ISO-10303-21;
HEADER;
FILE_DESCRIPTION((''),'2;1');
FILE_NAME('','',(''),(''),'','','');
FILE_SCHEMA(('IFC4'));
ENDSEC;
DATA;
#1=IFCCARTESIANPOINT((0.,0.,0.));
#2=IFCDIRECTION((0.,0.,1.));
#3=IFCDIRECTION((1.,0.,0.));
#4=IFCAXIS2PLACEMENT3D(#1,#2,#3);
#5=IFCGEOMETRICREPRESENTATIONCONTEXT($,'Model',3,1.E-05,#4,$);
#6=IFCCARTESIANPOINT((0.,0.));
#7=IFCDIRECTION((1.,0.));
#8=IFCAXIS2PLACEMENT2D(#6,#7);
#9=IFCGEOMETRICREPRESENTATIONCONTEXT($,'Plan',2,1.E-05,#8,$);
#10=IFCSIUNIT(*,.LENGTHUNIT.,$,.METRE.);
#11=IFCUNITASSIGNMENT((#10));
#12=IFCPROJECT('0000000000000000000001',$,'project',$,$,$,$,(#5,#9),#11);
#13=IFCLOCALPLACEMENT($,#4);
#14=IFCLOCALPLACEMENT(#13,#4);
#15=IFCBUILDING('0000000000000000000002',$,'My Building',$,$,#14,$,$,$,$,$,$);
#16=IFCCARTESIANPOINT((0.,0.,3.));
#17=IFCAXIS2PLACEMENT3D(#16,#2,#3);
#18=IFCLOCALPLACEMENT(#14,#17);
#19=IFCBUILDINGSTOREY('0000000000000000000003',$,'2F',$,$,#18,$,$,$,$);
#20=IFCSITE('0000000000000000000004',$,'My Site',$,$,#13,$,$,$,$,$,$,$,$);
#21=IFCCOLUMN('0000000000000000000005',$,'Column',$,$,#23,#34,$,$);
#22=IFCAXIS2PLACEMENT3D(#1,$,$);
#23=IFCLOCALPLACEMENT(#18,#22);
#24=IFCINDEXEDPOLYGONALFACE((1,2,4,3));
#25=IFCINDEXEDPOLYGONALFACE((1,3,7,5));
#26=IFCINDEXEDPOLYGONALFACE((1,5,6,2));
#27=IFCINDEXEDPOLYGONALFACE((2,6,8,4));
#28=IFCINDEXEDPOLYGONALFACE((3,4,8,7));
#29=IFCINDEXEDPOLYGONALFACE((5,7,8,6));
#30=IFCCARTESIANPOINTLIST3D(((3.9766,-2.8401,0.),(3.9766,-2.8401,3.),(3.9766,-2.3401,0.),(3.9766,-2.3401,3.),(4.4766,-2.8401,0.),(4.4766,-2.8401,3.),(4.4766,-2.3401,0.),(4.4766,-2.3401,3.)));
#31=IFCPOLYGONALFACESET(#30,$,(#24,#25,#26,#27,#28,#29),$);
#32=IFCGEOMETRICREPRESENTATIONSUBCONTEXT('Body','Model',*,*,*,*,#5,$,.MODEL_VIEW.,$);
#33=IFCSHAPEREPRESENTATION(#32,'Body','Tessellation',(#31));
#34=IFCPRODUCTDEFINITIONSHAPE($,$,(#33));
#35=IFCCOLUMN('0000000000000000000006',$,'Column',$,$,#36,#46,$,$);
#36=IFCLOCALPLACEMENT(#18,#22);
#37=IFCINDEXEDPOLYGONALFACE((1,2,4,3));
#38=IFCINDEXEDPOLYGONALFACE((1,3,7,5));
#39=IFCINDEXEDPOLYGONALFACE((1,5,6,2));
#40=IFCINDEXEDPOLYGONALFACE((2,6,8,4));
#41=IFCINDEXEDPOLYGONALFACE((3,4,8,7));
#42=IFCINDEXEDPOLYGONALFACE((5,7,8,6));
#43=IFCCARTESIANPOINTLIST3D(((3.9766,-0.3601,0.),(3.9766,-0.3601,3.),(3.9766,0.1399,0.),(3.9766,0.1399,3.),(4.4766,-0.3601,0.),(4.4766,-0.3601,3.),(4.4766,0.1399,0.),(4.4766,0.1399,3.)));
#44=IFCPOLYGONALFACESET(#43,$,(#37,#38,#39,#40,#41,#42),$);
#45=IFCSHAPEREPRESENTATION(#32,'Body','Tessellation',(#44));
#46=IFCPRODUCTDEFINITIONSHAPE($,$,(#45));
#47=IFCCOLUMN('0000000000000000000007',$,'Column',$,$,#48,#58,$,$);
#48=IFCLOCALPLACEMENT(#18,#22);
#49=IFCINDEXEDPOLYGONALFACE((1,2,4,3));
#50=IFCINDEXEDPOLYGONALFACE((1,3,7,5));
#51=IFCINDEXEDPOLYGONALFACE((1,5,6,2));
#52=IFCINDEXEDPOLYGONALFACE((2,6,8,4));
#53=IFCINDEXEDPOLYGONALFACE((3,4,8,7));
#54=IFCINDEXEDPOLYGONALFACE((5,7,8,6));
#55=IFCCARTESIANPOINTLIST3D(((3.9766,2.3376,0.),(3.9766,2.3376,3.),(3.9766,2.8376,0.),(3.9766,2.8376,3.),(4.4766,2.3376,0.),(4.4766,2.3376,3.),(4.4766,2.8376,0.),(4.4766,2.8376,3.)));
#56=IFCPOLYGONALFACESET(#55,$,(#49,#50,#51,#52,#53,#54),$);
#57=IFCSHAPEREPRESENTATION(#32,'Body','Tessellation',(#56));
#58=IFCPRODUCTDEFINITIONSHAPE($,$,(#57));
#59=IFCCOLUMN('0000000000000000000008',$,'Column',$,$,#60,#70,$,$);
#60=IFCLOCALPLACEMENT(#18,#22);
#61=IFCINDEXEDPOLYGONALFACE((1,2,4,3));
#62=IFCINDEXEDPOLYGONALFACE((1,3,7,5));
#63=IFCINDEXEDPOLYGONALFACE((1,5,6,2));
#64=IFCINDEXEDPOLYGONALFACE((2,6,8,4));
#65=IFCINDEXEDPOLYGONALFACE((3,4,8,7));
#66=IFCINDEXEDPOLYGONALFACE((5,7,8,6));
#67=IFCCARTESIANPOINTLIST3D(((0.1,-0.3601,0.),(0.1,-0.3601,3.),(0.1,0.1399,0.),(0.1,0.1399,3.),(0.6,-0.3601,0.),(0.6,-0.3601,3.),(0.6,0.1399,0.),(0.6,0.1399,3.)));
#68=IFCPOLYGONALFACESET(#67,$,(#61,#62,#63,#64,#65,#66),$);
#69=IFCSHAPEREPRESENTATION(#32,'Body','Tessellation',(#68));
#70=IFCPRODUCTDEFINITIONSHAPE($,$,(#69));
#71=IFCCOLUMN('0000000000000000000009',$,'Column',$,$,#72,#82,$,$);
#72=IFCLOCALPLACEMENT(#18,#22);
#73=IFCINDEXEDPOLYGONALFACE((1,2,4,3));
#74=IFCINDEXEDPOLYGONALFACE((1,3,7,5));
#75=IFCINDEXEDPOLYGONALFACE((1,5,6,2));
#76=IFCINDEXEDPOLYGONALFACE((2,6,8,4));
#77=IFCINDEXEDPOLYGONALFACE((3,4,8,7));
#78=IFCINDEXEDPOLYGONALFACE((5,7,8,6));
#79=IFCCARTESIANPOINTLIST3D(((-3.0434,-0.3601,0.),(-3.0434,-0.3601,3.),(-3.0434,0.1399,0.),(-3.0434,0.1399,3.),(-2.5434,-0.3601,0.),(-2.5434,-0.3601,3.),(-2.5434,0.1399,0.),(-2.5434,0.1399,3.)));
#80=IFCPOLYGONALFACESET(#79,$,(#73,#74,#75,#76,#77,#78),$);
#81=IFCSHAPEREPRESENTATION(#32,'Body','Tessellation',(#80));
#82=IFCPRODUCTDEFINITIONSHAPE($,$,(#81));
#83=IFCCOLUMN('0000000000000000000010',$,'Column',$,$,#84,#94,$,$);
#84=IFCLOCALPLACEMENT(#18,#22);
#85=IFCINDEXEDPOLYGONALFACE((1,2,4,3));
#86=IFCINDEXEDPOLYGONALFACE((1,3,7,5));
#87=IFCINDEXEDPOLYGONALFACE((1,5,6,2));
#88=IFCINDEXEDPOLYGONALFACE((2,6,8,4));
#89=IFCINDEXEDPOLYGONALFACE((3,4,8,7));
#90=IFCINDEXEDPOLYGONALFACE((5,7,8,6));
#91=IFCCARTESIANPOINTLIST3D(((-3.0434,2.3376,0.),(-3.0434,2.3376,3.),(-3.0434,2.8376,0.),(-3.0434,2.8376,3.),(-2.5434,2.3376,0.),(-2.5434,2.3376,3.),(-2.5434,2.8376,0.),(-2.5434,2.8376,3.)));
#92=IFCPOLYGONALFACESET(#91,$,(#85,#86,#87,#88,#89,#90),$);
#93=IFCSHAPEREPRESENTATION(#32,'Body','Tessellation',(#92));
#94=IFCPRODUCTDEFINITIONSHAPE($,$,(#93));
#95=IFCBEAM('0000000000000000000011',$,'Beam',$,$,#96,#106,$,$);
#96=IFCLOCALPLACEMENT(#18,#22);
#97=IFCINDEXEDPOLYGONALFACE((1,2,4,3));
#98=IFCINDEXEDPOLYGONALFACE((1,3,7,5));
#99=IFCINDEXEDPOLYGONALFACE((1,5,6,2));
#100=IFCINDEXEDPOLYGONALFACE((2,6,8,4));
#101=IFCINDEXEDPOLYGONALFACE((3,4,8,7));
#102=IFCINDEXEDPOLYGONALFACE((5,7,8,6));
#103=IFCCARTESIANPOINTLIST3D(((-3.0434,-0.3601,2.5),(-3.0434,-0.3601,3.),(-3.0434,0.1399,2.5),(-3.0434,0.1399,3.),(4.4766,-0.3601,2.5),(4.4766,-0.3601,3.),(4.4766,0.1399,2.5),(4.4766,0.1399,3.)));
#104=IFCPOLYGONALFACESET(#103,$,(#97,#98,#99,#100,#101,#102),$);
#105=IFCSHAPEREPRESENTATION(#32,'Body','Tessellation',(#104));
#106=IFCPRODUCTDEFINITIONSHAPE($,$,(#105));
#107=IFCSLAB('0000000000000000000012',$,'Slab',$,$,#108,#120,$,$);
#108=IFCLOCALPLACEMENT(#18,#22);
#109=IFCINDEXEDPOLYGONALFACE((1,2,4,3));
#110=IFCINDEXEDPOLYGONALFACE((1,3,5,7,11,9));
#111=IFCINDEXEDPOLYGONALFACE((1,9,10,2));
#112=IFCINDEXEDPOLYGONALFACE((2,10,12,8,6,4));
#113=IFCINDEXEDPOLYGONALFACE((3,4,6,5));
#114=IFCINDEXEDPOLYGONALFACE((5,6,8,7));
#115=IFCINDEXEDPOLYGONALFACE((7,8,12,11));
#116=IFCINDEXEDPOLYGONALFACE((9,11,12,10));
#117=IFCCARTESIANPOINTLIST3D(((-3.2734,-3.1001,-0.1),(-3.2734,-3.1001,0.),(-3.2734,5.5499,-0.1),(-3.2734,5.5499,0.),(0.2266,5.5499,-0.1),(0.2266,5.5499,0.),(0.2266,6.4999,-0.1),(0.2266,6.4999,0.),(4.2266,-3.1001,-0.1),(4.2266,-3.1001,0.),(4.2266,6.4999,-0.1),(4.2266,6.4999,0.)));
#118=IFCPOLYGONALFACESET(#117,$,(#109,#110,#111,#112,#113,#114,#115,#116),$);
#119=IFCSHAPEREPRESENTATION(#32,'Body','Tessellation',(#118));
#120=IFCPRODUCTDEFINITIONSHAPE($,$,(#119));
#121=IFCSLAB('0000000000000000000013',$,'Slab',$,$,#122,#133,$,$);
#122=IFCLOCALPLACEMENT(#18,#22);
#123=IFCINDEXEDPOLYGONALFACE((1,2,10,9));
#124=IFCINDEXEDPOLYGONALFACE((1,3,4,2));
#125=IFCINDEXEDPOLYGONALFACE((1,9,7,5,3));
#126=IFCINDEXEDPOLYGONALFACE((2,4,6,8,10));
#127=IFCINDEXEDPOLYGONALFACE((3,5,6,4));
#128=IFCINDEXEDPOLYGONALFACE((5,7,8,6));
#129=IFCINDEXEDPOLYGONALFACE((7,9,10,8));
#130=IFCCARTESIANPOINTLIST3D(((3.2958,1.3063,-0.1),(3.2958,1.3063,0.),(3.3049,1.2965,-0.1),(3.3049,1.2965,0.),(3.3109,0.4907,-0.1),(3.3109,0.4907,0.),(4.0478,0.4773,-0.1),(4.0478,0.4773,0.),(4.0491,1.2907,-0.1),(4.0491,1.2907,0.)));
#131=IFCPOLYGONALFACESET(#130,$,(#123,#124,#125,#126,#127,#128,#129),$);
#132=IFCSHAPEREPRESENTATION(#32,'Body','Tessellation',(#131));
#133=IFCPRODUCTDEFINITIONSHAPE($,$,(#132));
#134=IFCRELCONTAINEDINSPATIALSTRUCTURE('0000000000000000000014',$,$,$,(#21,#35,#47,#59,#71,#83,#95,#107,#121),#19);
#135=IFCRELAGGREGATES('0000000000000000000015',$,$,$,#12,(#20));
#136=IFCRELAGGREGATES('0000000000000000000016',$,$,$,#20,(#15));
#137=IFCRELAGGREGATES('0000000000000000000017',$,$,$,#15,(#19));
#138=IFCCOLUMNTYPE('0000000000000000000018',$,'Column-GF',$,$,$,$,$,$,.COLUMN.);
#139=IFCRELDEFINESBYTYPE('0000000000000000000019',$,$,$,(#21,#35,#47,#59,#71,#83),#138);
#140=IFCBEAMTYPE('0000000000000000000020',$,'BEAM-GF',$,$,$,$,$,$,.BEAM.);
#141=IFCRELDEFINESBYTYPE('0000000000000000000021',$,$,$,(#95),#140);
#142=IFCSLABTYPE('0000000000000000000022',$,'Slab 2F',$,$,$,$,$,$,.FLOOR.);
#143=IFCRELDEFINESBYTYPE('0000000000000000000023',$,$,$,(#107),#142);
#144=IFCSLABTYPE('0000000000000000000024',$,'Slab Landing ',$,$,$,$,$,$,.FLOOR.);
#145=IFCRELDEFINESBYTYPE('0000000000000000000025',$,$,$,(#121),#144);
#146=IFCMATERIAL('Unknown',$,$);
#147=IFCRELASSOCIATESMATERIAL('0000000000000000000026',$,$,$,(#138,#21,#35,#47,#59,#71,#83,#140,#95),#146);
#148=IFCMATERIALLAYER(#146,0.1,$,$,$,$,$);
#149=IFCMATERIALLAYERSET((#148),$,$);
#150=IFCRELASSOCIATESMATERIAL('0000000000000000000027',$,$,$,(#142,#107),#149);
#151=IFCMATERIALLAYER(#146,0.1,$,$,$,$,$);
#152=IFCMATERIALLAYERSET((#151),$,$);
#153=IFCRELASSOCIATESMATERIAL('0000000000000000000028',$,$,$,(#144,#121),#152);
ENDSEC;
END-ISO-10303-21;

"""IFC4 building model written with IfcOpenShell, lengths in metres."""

from ifc_helpers import new_model, si_unit, frame, origin_with_axes, origin_2d_with_axis, place, context, subcontext, project, spatial, indexed_curve, rectangle, outline, extrude, material, layer, layer_set, layer_usage, material_profile, profile_set, profile_usage, type_object, element, save


model = new_model("IFC4")

# Units and contexts
model_context = context("Model", 3, precision=1e-05, world=origin_with_axes())
plan_context = context("Plan", 2, precision=1e-05, world=origin_2d_with_axis())
body_context_1 = subcontext(model_context, "Body", "Model", "MODEL_VIEW")
ifc_project = project(units=[si_unit("LENGTHUNIT", "METRE")], contexts=[model_context, plan_context])

# Site, building, storey
site_placement = place(None, origin_with_axes())
site = spatial("IfcSite", under=ifc_project, at=site_placement, Name="My Site")
building_placement = place(site_placement, origin_with_axes())
building = spatial("IfcBuilding", under=site, at=building_placement, Name="My Building")
storey_placement = place(building_placement, frame((0.0, 0.0, 3.0), z_axis=(0.0, 0.0, 1.0), x_axis=(1.0, 0.0, 0.0)))
storey = spatial("IfcBuildingStorey", under=building, at=storey_placement, Name="2F")

# Columns
ifc_material = material(Name="Unknown")
ifc_material_profile_1 = material_profile(ifc_material, rectangle(XDim=0.5, YDim=0.5))
ifc_profile_set_1 = profile_set([ifc_material_profile_1])
ifc_profile_usage_1 = profile_usage(ifc_profile_set_1, cardinal=5)
column_type = type_object("IfcColumnType", Name="Column-GF", PredefinedType="COLUMN", material=ifc_profile_set_1)
column_1_placement = place(storey_placement, frame((4.2266, -2.5901, 0.0), z_axis=(0.0, 0.0, 1.0), x_axis=(1.0, 0.0, 0.0)))
element("IfcColumn", 1, at=column_1_placement, inside=storey, type_object=column_type, material=ifc_profile_usage_1, Name="Column", context=body_context_1, shape_type="SweptSolid", body=[
    extrude(rectangle(XDim=0.5, YDim=0.5), origin_with_axes(), (0.0, 0.0, 1.0), 3.0),
])
ifc_profile_usage_2 = profile_usage(ifc_profile_set_1, cardinal=7)
column_2_placement = place(storey_placement, frame((4.4766, 0.1399, 0.0), z_axis=(0.0, 0.0, 1.0), x_axis=(1.0, 0.0, 0.0)))
element("IfcColumn", 2, at=column_2_placement, inside=storey, type_object=column_type, material=ifc_profile_usage_2, Name="Column", context=body_context_1, shape_type="SweptSolid", body=[
    extrude(rectangle(XDim=0.5, YDim=0.5), frame((-0.25, -0.25, 0.0), z_axis=(0.0, 0.0, 1.0), x_axis=(1.0, 0.0, 0.0)), (0.0, 0.0, 1.0), 3.0),
])
ifc_profile_usage_3 = profile_usage(ifc_profile_set_1, cardinal=7)
column_3_placement = place(storey_placement, frame((4.4766, 2.8376, 0.0), z_axis=(0.0, 0.0, 1.0), x_axis=(1.0, 0.0, 0.0)))
element("IfcColumn", 3, at=column_3_placement, inside=storey, type_object=column_type, material=ifc_profile_usage_3, Name="Column", context=body_context_1, shape_type="SweptSolid", body=[
    extrude(rectangle(XDim=0.5, YDim=0.5), frame((-0.25, -0.25, 0.0), z_axis=(0.0, 0.0, 1.0), x_axis=(1.0, 0.0, 0.0)), (0.0, 0.0, 1.0), 3.0),
])
ifc_profile_usage_4 = profile_usage(ifc_profile_set_1, cardinal=7)
column_4_placement = place(storey_placement, frame((0.6, 0.1399, 0.0), z_axis=(0.0, 0.0, 1.0), x_axis=(1.0, 0.0, 0.0)))
element("IfcColumn", 4, at=column_4_placement, inside=storey, type_object=column_type, material=ifc_profile_usage_4, Name="Column", context=body_context_1, shape_type="SweptSolid", body=[
    extrude(rectangle(XDim=0.5, YDim=0.5), frame((-0.25, -0.25, 0.0), z_axis=(0.0, 0.0, 1.0), x_axis=(1.0, 0.0, 0.0)), (0.0, 0.0, 1.0), 3.0),
])
ifc_profile_usage_5 = profile_usage(ifc_profile_set_1, cardinal=7)
column_5_placement = place(storey_placement, frame((-2.5434, 0.1399, 0.0), z_axis=(0.0, 0.0, 1.0), x_axis=(1.0, 0.0, 0.0)))
element("IfcColumn", 5, at=column_5_placement, inside=storey, type_object=column_type, material=ifc_profile_usage_5, Name="Column", context=body_context_1, shape_type="SweptSolid", body=[
    extrude(rectangle(XDim=0.5, YDim=0.5), frame((-0.25, -0.25, 0.0), z_axis=(0.0, 0.0, 1.0), x_axis=(1.0, 0.0, 0.0)), (0.0, 0.0, 1.0), 3.0),
])
ifc_profile_usage_6 = profile_usage(ifc_profile_set_1, cardinal=7)
column_6_placement = place(storey_placement, frame((-2.5434, 2.8376, 0.0), z_axis=(0.0, 0.0, 1.0), x_axis=(1.0, 0.0, 0.0)))
element("IfcColumn", 6, at=column_6_placement, inside=storey, type_object=column_type, material=ifc_profile_usage_6, Name="Column", context=body_context_1, shape_type="SweptSolid", body=[
    extrude(rectangle(XDim=0.5, YDim=0.5), frame((-0.25, -0.25, 0.0), z_axis=(0.0, 0.0, 1.0), x_axis=(1.0, 0.0, 0.0)), (0.0, 0.0, 1.0), 3.0),
])

# Beam
ifc_material_profile_2 = material_profile(ifc_material, rectangle(XDim=0.5, YDim=0.5))
ifc_profile_set_2 = profile_set([ifc_material_profile_2])
ifc_profile_usage_7 = profile_usage(ifc_profile_set_2, cardinal=7)
beam_type = type_object("IfcBeamType", Name="BEAM-GF", PredefinedType="BEAM", material=ifc_profile_set_2)
beam_placement = place(storey_placement, frame((-3.0434, 0.1399, 3.0), z_axis=(1.0, 0.0, 0.0), x_axis=(0.0, 1.0, 0.0)))
element("IfcBeam", 7, at=beam_placement, inside=storey, type_object=beam_type, material=ifc_profile_usage_7, Name="Beam", context=body_context_1, shape_type="SweptSolid", body=[
    extrude(rectangle(XDim=0.5, YDim=0.5), frame((-0.25, -0.25, 0.0), z_axis=(0.0, 0.0, 1.0), x_axis=(1.0, 0.0, 0.0)), (0.0, 0.0, 1.0), 7.52),
])

# Slabs
ifc_layer_1 = layer(ifc_material, 0.1)
ifc_layer_set_1 = layer_set([ifc_layer_1])
ifc_layer_usage_1 = layer_usage(ifc_layer_set_1, "AXIS3", "POSITIVE", -0.1)
slab_type_1 = type_object("IfcSlabType", Name="Slab 2F", PredefinedType="FLOOR", material=ifc_layer_set_1)
slab_1_placement = place(storey_placement, frame((4.2266, -3.1001, 0.0), z_axis=(0.0, 0.0, 1.0), x_axis=(1.0, 0.0, 0.0)))
element("IfcSlab", 8, at=slab_1_placement, inside=storey, type_object=slab_type_1, material=ifc_layer_usage_1, Name="Slab", context=body_context_1, shape_type="SweptSolid", body=[
    extrude(outline(indexed_curve([(0.0, 0.0), (-7.5, 0.0), (-7.5, 8.65), (-4.0, 8.65), (-4.0, 9.6), (0.0, 9.6), (0.0, 0.0)])), frame((0.0, 0.0, -0.1), z_axis=(0.0, 0.0, 1.0), x_axis=(1.0, 0.0, 0.0)), (0.0, 0.0, 1.0), 0.1),
])
ifc_layer_2 = layer(ifc_material, 0.1)
ifc_layer_set_2 = layer_set([ifc_layer_2])
ifc_layer_usage_2 = layer_usage(ifc_layer_set_2, "AXIS3", "POSITIVE", -0.1)
slab_type_2 = type_object("IfcSlabType", Name="Slab Landing ", PredefinedType="FLOOR", material=ifc_layer_set_2)
slab_2_placement = place(storey_placement, frame((3.2958, 1.3063, 0.0), z_axis=(0.0, 0.0, 1.0), x_axis=(1.0, 0.0, 0.0)))
element("IfcSlab", 9, at=slab_2_placement, inside=storey, type_object=slab_type_2, material=ifc_layer_usage_2, Name="Slab", context=body_context_1, shape_type="SweptSolid", body=[
    extrude(outline(indexed_curve([(0.0, 0.0), (0.7532, -0.0155), (0.7519, -0.8289), (0.015, -0.8155), (0.0091, -0.0097), (0.0, 0.0)])), frame((0.0, 0.0, -0.1), z_axis=(0.0, 0.0, 1.0), x_axis=(1.0, 0.0, 0.0)), (0.0, 0.0, 1.0), 0.1),
])

save(model, "model.ifc")
